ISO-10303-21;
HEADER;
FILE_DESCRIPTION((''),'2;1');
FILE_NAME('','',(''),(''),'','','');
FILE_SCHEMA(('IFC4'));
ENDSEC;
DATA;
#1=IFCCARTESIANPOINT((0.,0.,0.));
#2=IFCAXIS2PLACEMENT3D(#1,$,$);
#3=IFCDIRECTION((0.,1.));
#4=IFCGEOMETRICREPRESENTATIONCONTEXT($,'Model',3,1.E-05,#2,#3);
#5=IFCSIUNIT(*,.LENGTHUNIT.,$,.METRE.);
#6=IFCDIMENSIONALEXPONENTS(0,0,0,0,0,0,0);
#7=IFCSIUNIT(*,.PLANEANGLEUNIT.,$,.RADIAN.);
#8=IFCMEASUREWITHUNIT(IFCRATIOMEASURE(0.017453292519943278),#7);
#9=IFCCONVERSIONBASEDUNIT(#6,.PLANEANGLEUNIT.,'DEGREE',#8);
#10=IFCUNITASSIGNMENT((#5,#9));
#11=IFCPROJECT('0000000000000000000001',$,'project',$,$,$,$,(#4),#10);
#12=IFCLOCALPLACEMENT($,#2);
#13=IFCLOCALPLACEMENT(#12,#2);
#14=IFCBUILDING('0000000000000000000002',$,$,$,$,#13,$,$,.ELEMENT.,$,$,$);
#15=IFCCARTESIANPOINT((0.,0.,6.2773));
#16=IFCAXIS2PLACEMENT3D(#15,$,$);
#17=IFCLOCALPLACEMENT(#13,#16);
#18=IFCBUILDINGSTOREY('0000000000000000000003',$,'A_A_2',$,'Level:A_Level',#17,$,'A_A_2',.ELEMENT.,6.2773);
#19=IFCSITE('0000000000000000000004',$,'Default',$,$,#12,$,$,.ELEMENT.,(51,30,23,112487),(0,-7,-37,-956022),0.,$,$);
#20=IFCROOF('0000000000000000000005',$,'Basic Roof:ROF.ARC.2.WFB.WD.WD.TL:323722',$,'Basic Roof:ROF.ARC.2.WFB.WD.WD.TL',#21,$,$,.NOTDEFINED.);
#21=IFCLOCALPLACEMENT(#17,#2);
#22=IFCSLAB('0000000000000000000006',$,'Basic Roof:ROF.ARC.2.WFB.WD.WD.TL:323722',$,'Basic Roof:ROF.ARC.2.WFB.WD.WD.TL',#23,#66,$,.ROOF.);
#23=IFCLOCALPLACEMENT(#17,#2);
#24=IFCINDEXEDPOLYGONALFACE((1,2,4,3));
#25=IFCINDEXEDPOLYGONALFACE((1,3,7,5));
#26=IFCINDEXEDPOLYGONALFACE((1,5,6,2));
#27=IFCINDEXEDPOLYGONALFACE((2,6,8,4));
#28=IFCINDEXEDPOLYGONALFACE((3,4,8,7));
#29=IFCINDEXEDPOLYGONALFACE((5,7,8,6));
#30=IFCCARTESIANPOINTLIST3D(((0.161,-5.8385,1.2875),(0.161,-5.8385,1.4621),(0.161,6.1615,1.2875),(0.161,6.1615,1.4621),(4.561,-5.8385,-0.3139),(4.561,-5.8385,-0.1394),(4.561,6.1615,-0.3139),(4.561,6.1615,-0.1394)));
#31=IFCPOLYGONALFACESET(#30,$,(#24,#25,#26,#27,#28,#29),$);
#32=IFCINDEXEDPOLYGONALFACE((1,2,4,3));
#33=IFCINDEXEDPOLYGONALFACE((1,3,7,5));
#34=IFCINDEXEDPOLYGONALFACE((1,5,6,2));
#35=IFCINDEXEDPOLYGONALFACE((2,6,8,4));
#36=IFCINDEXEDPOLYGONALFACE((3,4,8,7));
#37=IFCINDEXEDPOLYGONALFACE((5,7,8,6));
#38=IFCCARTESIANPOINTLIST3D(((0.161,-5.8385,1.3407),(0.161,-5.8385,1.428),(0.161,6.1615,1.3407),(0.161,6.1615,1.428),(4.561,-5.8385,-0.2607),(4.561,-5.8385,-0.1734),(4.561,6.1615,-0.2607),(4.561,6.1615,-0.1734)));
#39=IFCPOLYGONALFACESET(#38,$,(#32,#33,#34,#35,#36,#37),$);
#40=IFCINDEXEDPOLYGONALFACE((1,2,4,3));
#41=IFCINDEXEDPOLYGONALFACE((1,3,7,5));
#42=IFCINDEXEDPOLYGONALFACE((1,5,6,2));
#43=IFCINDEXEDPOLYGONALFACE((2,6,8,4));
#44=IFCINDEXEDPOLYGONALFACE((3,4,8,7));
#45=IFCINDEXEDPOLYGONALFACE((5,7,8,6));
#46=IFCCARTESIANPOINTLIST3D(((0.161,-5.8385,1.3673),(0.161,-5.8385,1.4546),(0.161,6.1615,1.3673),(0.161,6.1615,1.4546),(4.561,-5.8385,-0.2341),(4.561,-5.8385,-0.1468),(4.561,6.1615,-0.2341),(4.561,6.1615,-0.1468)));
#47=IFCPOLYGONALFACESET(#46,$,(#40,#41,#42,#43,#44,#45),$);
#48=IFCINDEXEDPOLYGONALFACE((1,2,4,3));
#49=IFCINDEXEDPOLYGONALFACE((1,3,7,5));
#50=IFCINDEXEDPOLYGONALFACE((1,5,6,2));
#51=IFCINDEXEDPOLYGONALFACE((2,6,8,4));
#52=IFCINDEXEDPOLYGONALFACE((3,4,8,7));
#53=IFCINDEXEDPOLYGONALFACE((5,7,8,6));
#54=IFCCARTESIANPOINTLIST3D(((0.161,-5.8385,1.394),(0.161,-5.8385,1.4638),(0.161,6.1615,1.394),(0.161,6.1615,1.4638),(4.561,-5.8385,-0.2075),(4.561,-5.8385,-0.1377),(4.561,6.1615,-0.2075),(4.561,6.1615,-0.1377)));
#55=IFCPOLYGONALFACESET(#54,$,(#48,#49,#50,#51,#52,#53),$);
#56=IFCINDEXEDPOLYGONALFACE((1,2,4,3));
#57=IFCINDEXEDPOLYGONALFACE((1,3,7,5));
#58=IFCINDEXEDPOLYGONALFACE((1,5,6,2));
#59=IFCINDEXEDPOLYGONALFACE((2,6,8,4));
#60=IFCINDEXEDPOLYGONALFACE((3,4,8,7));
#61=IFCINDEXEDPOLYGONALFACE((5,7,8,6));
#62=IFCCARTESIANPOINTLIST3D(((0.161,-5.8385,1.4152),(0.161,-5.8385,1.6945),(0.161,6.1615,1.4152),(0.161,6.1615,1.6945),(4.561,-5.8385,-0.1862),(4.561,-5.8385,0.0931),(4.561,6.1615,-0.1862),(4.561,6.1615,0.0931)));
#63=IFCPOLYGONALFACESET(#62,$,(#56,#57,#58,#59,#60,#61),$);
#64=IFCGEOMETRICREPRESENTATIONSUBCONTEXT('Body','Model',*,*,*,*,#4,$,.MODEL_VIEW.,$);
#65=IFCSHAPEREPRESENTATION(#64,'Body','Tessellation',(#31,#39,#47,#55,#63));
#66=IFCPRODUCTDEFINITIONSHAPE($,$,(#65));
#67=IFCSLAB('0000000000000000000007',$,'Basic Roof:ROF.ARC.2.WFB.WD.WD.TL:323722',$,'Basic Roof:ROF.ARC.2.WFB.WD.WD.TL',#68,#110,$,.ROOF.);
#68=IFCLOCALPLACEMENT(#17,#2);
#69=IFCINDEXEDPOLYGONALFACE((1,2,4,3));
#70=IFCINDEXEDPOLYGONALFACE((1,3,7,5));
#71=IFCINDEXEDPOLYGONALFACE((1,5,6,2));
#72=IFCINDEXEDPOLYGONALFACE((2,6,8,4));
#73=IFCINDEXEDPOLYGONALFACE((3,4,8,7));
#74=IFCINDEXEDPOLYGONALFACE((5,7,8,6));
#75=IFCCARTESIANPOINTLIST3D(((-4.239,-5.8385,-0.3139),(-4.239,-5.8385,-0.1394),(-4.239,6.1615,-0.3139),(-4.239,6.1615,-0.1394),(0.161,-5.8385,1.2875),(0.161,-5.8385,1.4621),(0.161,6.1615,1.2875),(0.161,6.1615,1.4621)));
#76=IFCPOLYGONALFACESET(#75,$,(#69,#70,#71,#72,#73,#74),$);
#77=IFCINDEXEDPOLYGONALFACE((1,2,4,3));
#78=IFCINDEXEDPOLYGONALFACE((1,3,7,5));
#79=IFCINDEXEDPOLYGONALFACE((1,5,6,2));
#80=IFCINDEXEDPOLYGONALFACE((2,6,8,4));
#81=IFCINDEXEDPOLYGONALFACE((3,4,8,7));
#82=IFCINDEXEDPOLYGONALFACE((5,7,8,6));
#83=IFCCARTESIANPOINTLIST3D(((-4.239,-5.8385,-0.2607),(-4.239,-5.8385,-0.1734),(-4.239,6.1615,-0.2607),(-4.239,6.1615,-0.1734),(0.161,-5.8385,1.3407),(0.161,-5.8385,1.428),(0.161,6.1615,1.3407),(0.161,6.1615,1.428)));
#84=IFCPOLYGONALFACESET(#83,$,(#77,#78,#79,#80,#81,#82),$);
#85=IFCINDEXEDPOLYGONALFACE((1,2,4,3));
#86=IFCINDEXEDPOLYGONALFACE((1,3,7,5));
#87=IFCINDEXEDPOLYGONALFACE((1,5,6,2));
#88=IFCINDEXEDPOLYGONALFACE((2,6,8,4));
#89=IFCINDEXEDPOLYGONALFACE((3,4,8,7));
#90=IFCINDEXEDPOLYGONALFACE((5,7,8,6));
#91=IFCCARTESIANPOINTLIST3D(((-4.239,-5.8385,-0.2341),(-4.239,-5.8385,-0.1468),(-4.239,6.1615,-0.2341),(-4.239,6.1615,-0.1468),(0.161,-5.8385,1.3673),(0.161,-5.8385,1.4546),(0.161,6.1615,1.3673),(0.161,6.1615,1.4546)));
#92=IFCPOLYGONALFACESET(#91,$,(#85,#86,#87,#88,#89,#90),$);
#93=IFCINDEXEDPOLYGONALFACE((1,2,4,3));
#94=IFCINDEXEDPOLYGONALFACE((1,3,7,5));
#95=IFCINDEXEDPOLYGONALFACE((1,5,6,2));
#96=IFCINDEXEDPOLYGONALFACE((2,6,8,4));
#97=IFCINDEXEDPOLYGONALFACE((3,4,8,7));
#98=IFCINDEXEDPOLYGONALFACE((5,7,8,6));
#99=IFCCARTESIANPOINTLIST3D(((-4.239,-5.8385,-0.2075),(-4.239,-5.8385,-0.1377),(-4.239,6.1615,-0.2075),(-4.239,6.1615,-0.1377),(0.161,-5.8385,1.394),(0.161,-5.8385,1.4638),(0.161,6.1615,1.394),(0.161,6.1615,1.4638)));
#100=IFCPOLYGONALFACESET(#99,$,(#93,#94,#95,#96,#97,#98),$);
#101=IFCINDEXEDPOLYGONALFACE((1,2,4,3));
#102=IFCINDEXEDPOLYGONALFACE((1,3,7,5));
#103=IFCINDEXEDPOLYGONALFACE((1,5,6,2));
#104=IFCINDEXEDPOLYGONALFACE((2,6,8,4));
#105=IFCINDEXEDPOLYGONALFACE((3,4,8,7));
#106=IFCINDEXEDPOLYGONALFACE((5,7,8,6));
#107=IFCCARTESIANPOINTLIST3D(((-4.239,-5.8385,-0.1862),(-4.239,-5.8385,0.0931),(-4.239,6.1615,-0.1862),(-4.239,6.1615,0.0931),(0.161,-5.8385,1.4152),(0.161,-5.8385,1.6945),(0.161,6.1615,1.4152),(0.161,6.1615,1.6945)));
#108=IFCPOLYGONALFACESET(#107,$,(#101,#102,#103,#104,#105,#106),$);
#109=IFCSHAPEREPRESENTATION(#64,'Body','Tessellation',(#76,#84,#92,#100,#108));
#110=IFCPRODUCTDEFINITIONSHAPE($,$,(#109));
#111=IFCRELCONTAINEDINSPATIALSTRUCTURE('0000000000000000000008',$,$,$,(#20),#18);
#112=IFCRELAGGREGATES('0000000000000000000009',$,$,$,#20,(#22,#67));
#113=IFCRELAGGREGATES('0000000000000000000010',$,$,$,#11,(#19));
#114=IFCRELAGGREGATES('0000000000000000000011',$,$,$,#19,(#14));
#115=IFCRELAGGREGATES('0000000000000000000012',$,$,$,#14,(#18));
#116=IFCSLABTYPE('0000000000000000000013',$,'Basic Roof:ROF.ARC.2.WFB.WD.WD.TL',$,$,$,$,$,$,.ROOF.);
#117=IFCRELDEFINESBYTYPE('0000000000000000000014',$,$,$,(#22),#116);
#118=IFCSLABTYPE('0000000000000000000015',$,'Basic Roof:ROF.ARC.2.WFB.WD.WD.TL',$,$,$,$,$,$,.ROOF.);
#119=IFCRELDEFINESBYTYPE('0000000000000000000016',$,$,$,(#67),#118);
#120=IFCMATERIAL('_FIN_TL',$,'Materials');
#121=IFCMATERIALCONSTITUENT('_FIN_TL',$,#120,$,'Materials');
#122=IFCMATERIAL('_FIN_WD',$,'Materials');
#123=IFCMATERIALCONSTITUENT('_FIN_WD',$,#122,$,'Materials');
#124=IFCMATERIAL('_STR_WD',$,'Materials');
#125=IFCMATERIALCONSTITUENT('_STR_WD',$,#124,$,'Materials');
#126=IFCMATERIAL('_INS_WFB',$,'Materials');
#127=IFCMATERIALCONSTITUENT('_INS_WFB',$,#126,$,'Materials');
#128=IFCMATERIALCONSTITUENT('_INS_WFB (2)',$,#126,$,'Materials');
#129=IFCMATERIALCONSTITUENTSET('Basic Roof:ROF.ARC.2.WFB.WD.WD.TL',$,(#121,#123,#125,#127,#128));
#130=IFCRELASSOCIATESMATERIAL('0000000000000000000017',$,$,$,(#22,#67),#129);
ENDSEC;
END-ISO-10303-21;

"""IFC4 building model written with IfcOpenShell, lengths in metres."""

from ifc_helpers import new_model, entity, si_unit, converted_unit, direction, frame, origin, place, context, subcontext, project, spatial, indexed_curve, outline, extrude, material, constituent, constituent_set, type_object, element, aggregate, save


model = new_model("IFC4")

# Units and contexts
model_context = context("Model", 3, precision=1e-05, world=origin(), true_north=direction((0.0, 1.0)))
body_context = subcontext(model_context, "Body", "Model", "MODEL_VIEW")
ifc_project = project(units=[si_unit("LENGTHUNIT", "METRE"), converted_unit("PLANEANGLEUNIT", "DEGREE", entity("IfcRatioMeasure", 0.017453292519943278), si_unit("PLANEANGLEUNIT", "RADIAN"), dimensions=[0, 0, 0, 0, 0, 0, 0])], contexts=[model_context])

# Site, building, storey
site_placement = place(None, origin())
site = spatial("IfcSite", under=ifc_project, at=site_placement, Name="Default", CompositionType="ELEMENT", RefLatitude=(51, 30, 23, 112487), RefLongitude=(0, -7, -37, -956022), RefElevation=0.0)
building_placement = place(site_placement, origin())
building = spatial("IfcBuilding", under=site, at=building_placement, CompositionType="ELEMENT")
storey_placement = place(building_placement, frame((0.0, 0.0, 6.2773)))
storey = spatial("IfcBuildingStorey", under=building, at=storey_placement, Name="A_A_2", ObjectType="Level:A_Level", LongName="A_A_2", CompositionType="ELEMENT", Elevation=6.2773)

# Roof, slabs
roof_placement = place(storey_placement, frame((-4.239, -5.8385, -0.3139)))
roof = element("IfcRoof", 1, at=roof_placement, inside=storey, Name="Basic Roof:ROF.ARC.2.WFB.WD.WD.TL:323722", ObjectType="Basic Roof:ROF.ARC.2.WFB.WD.WD.TL", PredefinedType="NOTDEFINED")
ifc_material_1 = material(Name="_FIN_TL", Category="Materials")
ifc_constituent_1 = constituent(ifc_material_1, Name="_FIN_TL", Category="Materials")
ifc_material_2 = material(Name="_FIN_WD", Category="Materials")
ifc_constituent_2 = constituent(ifc_material_2, Name="_FIN_WD", Category="Materials")
ifc_material_3 = material(Name="_STR_WD", Category="Materials")
ifc_constituent_3 = constituent(ifc_material_3, Name="_STR_WD", Category="Materials")
ifc_material_4 = material(Name="_INS_WFB", Category="Materials")
ifc_constituent_4 = constituent(ifc_material_4, Name="_INS_WFB", Category="Materials")
ifc_constituent_5 = constituent(ifc_material_4, Name="_INS_WFB (2)", Category="Materials")
ifc_constituent_set = constituent_set(constituents=[ifc_constituent_1, ifc_constituent_2, ifc_constituent_3, ifc_constituent_4, ifc_constituent_5], Name="Basic Roof:ROF.ARC.2.WFB.WD.WD.TL")
slab_type_1 = type_object("IfcSlabType", Name="Basic Roof:ROF.ARC.2.WFB.WD.WD.TL", PredefinedType="ROOF")
slab_1_placement = place(roof_placement, origin())
slab_1 = element("IfcSlab", 2, at=slab_1_placement, type_object=slab_type_1, material=ifc_constituent_set, Name="Basic Roof:ROF.ARC.2.WFB.WD.WD.TL:323722", ObjectType="Basic Roof:ROF.ARC.2.WFB.WD.WD.TL", PredefinedType="ROOF", context=body_context, shape_type="SweptSolid", body=[
    extrude(outline(indexed_curve([(-2.3412, 6.0), (-2.3412, -6.0), (2.3412, -6.0), (2.3412, 6.0), (-2.3412, 6.0)], self_intersect=False)), frame((6.6, 6.0, 0.8007), z_axis=(0.34202, 0.0, 0.939693), x_axis=(0.939693, 0.0, -0.34202)), (-0.34202, 0.0, 0.939693), 0.1746),
    extrude(outline(indexed_curve([(-2.3412, 6.0), (-2.3412, -6.0), (2.3412, -6.0), (2.3412, 6.0), (-2.3412, 6.0)], self_intersect=False)), frame((6.6, 6.0, 0.8539), z_axis=(0.34202, 0.0, 0.939693), x_axis=(0.939693, 0.0, -0.34202)), (-0.34202, 0.0, 0.939693), 0.0873),
    extrude(outline(indexed_curve([(-2.3412, 6.0), (-2.3412, -6.0), (2.3412, -6.0), (2.3412, 6.0), (-2.3412, 6.0)], self_intersect=False)), frame((6.6, 6.0, 0.8805), z_axis=(0.34202, 0.0, 0.939693), x_axis=(0.939693, 0.0, -0.34202)), (-0.34202, 0.0, 0.939693), 0.0873),
    extrude(outline(indexed_curve([(-2.3412, 6.0), (-2.3412, -6.0), (2.3412, -6.0), (2.3412, 6.0), (-2.3412, 6.0)], self_intersect=False)), frame((6.6, 6.0, 0.9072), z_axis=(0.34202, 0.0, 0.939693), x_axis=(0.939693, 0.0, -0.34202)), (-0.34202, 0.0, 0.939693), 0.0698),
    extrude(outline(indexed_curve([(-2.3412, 6.0), (-2.3412, -6.0), (2.3412, -6.0), (2.3412, 6.0), (-2.3412, 6.0)], self_intersect=False)), frame((6.6, 6.0, 0.9284), z_axis=(0.34202, 0.0, 0.939693), x_axis=(0.939693, 0.0, -0.34202)), (-0.34202, 0.0, 0.939693), 0.2793),
])
slab_type_2 = type_object("IfcSlabType", Name="Basic Roof:ROF.ARC.2.WFB.WD.WD.TL", PredefinedType="ROOF")
slab_2_placement = place(roof_placement, origin())
slab_2 = element("IfcSlab", 3, at=slab_2_placement, type_object=slab_type_2, material=ifc_constituent_set, Name="Basic Roof:ROF.ARC.2.WFB.WD.WD.TL:323722", ObjectType="Basic Roof:ROF.ARC.2.WFB.WD.WD.TL", PredefinedType="ROOF", context=body_context, shape_type="SweptSolid", body=[
    extrude(outline(indexed_curve([(-2.3412, -6.0), (2.3412, -6.0), (2.3412, 6.0), (-2.3412, 6.0), (-2.3412, -6.0)], self_intersect=False)), frame((2.2, 6.0, 0.8007), z_axis=(-0.34202, 0.0, 0.939693), x_axis=(0.939693, 0.0, 0.34202)), (0.34202, 0.0, 0.939693), 0.1746),
    extrude(outline(indexed_curve([(-2.3412, -6.0), (2.3412, -6.0), (2.3412, 6.0), (-2.3412, 6.0), (-2.3412, -6.0)], self_intersect=False)), frame((2.2, 6.0, 0.8539), z_axis=(-0.34202, 0.0, 0.939693), x_axis=(0.939693, 0.0, 0.34202)), (0.34202, 0.0, 0.939693), 0.0873),
    extrude(outline(indexed_curve([(-2.3412, -6.0), (2.3412, -6.0), (2.3412, 6.0), (-2.3412, 6.0), (-2.3412, -6.0)], self_intersect=False)), frame((2.2, 6.0, 0.8805), z_axis=(-0.34202, 0.0, 0.939693), x_axis=(0.939693, 0.0, 0.34202)), (0.34202, 0.0, 0.939693), 0.0873),
    extrude(outline(indexed_curve([(-2.3412, -6.0), (2.3412, -6.0), (2.3412, 6.0), (-2.3412, 6.0), (-2.3412, -6.0)], self_intersect=False)), frame((2.2, 6.0, 0.9072), z_axis=(-0.34202, 0.0, 0.939693), x_axis=(0.939693, 0.0, 0.34202)), (0.34202, 0.0, 0.939693), 0.0698),
    extrude(outline(indexed_curve([(-2.3412, -6.0), (2.3412, -6.0), (2.3412, 6.0), (-2.3412, 6.0), (-2.3412, -6.0)], self_intersect=False)), frame((2.2, 6.0, 0.9284), z_axis=(-0.34202, 0.0, 0.939693), x_axis=(0.939693, 0.0, 0.34202)), (0.34202, 0.0, 0.939693), 0.2793),
])
aggregate(roof, [slab_1, slab_2])

save(model, "model.ifc")
